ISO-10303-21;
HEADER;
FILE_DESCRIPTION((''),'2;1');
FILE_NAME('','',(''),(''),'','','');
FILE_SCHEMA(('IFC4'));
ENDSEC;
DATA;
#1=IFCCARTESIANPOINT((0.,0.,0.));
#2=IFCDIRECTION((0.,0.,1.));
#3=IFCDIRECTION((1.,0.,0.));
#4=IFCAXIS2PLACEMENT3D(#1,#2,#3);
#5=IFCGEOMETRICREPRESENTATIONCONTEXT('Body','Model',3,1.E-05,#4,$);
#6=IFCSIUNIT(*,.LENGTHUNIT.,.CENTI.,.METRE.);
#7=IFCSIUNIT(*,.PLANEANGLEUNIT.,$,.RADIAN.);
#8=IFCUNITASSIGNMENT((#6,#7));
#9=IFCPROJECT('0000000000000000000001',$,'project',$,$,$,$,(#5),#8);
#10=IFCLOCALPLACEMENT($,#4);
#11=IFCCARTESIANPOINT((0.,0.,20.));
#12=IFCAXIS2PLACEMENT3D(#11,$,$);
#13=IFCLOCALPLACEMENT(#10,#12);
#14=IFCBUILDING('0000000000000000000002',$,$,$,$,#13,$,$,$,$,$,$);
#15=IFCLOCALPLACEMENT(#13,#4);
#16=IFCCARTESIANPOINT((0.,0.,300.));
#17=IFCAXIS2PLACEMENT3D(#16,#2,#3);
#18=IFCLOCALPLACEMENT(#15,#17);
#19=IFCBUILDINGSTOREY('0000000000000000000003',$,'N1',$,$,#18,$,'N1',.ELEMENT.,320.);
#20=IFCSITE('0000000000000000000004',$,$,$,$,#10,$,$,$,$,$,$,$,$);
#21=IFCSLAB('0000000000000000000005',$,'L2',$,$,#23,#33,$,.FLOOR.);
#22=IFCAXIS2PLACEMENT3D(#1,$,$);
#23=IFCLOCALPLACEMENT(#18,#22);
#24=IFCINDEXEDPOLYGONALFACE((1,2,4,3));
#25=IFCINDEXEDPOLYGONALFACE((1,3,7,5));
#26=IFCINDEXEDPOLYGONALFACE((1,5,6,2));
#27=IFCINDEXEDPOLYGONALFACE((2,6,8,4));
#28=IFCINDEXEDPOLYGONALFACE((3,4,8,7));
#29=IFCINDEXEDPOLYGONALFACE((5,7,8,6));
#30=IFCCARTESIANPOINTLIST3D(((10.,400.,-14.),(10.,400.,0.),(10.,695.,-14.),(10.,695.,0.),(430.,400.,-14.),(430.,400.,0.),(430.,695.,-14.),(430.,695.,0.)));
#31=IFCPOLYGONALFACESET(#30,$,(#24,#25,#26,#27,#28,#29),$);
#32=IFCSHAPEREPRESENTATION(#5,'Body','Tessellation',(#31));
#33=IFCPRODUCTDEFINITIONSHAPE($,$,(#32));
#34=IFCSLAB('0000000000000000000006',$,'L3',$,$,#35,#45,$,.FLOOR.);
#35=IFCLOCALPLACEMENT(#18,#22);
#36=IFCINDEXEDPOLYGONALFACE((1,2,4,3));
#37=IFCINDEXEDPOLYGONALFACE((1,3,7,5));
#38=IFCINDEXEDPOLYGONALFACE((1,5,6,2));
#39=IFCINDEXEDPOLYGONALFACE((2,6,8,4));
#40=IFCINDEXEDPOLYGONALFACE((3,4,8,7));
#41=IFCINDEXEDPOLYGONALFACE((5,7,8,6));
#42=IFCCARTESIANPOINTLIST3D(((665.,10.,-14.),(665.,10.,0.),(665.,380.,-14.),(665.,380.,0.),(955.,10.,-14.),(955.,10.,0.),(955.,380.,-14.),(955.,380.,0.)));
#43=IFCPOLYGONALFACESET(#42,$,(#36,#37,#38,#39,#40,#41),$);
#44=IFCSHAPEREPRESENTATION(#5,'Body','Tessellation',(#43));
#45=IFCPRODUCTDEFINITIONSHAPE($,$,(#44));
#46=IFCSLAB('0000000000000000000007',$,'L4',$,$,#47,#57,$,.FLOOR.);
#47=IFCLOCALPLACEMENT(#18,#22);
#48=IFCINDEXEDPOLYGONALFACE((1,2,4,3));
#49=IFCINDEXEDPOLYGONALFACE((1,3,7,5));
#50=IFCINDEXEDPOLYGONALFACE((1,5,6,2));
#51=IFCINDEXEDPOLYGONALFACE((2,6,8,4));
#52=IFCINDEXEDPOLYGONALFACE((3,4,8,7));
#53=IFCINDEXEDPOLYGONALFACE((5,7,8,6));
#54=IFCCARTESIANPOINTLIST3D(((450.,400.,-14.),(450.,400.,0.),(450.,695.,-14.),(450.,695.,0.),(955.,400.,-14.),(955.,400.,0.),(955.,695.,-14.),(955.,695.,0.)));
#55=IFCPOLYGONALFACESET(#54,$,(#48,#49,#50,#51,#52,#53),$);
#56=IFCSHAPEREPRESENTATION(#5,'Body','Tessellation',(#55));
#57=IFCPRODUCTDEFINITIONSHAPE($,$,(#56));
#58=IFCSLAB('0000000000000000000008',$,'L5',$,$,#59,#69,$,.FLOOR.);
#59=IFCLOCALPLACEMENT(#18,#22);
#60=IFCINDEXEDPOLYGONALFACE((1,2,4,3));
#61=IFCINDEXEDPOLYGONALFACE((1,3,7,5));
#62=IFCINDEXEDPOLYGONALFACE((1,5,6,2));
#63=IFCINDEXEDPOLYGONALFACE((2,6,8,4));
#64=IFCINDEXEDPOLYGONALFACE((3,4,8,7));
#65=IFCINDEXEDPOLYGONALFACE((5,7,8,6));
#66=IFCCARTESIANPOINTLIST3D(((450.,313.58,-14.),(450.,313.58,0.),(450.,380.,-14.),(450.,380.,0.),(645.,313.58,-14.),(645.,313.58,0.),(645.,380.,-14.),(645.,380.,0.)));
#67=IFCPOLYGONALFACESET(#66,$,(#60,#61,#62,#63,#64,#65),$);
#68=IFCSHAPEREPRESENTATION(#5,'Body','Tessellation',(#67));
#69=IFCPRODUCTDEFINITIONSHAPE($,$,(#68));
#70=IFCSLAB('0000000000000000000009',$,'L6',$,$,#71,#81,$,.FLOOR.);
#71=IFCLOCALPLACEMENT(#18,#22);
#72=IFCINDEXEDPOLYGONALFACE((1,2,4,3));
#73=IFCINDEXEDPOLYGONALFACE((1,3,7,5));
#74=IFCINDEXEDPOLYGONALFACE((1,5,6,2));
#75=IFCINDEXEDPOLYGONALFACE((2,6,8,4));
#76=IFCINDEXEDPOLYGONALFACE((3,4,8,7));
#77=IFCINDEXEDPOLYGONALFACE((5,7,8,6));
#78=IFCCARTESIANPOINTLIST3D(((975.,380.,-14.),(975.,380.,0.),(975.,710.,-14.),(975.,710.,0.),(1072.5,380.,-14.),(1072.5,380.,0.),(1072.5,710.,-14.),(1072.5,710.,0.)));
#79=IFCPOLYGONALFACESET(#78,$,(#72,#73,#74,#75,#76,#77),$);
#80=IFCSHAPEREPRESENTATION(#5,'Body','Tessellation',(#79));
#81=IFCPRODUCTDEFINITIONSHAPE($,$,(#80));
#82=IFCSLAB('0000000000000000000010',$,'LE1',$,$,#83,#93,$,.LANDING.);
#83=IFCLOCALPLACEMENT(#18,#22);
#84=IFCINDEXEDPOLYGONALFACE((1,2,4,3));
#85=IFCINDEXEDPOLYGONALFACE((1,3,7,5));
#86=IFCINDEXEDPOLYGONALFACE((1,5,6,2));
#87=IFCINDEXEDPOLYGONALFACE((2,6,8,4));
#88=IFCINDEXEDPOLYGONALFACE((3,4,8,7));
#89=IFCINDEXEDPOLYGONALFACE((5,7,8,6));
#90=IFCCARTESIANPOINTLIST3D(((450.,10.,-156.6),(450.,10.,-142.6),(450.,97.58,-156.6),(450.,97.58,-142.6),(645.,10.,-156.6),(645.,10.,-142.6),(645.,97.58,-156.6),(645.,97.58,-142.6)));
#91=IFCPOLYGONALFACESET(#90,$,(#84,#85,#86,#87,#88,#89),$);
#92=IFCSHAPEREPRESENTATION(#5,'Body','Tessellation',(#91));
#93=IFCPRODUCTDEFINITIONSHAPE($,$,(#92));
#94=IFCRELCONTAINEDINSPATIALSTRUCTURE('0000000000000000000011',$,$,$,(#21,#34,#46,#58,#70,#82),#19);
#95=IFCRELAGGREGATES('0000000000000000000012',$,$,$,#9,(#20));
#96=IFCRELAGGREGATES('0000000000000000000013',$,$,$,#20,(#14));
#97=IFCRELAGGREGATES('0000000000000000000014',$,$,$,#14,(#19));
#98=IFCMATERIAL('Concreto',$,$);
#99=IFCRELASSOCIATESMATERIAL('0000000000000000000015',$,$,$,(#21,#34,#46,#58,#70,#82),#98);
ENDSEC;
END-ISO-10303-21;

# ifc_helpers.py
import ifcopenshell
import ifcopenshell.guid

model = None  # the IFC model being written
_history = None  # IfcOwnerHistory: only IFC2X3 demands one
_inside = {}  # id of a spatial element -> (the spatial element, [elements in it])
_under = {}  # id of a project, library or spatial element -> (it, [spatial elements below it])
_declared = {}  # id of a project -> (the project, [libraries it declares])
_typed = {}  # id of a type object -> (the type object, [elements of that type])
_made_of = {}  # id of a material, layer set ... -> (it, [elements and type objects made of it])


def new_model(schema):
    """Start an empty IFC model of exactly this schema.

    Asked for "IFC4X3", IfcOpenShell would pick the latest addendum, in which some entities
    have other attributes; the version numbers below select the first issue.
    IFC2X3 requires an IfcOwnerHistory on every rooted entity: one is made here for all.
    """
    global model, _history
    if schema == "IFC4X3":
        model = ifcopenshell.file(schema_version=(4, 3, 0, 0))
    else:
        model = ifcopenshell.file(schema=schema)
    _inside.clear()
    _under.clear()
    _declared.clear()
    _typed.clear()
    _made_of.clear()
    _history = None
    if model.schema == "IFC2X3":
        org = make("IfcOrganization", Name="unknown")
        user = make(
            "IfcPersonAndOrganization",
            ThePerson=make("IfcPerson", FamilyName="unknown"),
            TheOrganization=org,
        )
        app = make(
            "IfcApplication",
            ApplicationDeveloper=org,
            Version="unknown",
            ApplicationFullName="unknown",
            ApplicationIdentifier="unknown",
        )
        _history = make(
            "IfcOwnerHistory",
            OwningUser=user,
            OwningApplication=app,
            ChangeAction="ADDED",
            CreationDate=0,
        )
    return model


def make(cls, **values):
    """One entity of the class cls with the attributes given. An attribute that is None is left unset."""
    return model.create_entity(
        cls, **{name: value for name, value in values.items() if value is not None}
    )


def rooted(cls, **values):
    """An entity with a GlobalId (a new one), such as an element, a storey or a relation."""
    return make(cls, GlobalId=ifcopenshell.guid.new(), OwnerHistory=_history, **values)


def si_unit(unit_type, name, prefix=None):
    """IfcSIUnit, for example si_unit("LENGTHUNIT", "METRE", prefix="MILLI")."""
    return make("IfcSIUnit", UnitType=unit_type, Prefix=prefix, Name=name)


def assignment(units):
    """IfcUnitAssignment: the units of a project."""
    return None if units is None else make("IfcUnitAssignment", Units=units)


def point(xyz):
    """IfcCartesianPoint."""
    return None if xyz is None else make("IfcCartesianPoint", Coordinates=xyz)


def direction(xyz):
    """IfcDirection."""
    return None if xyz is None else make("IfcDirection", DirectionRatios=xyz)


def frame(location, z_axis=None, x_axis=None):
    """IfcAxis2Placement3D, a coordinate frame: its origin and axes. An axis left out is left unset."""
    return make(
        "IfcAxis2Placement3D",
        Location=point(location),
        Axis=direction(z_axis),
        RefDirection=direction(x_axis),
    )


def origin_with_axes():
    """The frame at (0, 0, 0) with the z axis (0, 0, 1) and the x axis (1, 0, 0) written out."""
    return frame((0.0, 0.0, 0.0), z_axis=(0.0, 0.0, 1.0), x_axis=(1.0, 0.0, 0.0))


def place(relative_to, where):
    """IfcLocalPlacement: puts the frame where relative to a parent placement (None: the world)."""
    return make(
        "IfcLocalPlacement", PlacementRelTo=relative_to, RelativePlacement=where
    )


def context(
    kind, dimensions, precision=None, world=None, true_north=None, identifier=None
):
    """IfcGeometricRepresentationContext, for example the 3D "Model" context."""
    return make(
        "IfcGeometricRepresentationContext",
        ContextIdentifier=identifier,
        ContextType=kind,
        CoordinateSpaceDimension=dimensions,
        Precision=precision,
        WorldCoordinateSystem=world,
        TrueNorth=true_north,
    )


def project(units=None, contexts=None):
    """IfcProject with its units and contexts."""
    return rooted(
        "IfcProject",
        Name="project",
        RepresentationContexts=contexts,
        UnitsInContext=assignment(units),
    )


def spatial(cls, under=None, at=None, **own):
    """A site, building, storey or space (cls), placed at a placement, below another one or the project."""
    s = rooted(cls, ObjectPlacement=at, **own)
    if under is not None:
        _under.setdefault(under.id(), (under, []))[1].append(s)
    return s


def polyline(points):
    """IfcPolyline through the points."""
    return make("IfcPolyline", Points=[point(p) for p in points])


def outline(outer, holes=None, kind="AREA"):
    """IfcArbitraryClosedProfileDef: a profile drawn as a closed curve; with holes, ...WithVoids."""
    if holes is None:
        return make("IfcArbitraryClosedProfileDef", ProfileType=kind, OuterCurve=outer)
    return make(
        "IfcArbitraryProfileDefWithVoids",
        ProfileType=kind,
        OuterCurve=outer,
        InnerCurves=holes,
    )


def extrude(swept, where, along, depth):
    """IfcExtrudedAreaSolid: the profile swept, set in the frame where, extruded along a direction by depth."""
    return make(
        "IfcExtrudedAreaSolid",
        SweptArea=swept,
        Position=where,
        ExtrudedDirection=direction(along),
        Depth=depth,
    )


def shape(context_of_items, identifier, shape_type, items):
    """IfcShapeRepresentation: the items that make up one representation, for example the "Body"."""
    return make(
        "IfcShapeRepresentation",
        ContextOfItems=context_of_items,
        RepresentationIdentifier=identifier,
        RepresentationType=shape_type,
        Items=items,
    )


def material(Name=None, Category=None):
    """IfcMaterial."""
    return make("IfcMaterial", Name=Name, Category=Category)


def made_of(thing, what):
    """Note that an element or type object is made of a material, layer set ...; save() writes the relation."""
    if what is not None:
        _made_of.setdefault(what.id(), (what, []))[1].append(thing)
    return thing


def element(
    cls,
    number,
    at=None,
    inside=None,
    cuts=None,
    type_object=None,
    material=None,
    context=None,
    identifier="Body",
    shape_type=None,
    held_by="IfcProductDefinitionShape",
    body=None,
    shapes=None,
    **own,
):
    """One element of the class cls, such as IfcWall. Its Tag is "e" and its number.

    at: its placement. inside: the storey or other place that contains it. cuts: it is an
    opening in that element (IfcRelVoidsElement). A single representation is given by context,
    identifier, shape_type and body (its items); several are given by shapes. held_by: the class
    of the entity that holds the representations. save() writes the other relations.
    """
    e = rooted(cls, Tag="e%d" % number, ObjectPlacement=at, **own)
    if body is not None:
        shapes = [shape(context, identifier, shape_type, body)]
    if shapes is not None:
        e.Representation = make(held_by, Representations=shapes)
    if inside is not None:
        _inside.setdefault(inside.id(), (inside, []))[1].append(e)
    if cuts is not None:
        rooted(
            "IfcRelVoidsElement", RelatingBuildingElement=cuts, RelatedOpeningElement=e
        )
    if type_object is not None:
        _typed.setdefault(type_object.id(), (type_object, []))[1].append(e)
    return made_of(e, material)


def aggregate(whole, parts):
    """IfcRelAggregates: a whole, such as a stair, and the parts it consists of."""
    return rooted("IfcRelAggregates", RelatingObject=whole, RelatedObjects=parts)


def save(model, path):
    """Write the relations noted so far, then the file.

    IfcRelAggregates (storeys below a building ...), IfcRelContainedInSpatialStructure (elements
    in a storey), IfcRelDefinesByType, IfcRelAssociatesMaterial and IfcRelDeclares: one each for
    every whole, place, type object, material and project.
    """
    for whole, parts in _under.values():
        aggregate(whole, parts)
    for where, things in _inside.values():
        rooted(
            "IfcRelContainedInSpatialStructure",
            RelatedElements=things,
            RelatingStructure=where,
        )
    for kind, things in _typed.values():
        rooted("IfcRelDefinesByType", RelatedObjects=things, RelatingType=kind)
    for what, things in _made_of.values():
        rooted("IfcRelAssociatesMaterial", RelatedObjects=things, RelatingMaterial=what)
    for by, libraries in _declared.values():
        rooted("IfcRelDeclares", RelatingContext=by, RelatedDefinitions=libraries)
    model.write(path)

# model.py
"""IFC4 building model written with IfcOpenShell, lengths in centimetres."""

from ifc_helpers import new_model, si_unit, frame, origin_with_axes, place, context, project, spatial, polyline, outline, extrude, material, element, save


model = new_model("IFC4")

# Units and contexts
model_context = context("Model", 3, precision=1e-05, world=origin_with_axes(), identifier="Body")
ifc_project = project(units=[si_unit("LENGTHUNIT", "METRE", prefix="CENTI"), si_unit("PLANEANGLEUNIT", "RADIAN")], contexts=[model_context])

# Site, building, storey
site_placement = place(None, origin_with_axes())
site = spatial("IfcSite", under=ifc_project, at=site_placement)
building_placement = place(site_placement, frame((0.0, 0.0, 20.0)))
building = spatial("IfcBuilding", under=site, at=building_placement)
placement = place(building_placement, origin_with_axes())
storey_placement = place(placement, frame((0.0, 0.0, 300.0), z_axis=(0.0, 0.0, 1.0), x_axis=(1.0, 0.0, 0.0)))
storey = spatial("IfcBuildingStorey", under=building, at=storey_placement, Name="N1", LongName="N1", CompositionType="ELEMENT", Elevation=320.0)

# Shared definitions
ifc_material = material(Name="Concreto")

# Slabs
slab_1_placement = place(storey_placement, frame((220.0, 547.5, 0.0), z_axis=(0.0, 0.0, 1.0), x_axis=(1.0, 0.0, 0.0)))
element("IfcSlab", 1, at=slab_1_placement, inside=storey, material=ifc_material, Name="L2", PredefinedType="FLOOR", context=model_context, shape_type="SolidModel", body=[
    extrude(outline(polyline([(210.0, 147.5), (-210.0, 147.5), (-210.0, -147.5), (210.0, -147.5), (210.0, 147.5), (210.0, 147.5)])), frame((0.0, 0.0, -14.0), z_axis=(0.0, 0.0, 1.0), x_axis=(1.0, 0.0, 0.0)), (0.0, 0.0, 1.0), 14.0),
])
slab_2_placement = place(storey_placement, frame((810.0, 195.0, 0.0), z_axis=(0.0, 0.0, 1.0), x_axis=(1.0, 0.0, 0.0)))
element("IfcSlab", 2, at=slab_2_placement, inside=storey, material=ifc_material, Name="L3", PredefinedType="FLOOR", context=model_context, shape_type="SolidModel", body=[
    extrude(outline(polyline([(145.0, 185.0), (-145.0, 185.0), (-145.0, -185.0), (145.0, -185.0), (145.0, 185.0), (145.0, 185.0)])), frame((0.0, 0.0, -14.0), z_axis=(0.0, 0.0, 1.0), x_axis=(1.0, 0.0, 0.0)), (0.0, 0.0, 1.0), 14.0),
])
slab_3_placement = place(storey_placement, frame((702.5, 547.5, 0.0), z_axis=(0.0, 0.0, 1.0), x_axis=(1.0, 0.0, 0.0)))
element("IfcSlab", 3, at=slab_3_placement, inside=storey, material=ifc_material, Name="L4", PredefinedType="FLOOR", context=model_context, shape_type="SolidModel", body=[
    extrude(outline(polyline([(252.5, 147.5), (-252.5, 147.5), (-252.5, -147.5), (252.5, -147.5), (252.5, 147.5), (252.5, 147.5)])), frame((0.0, 0.0, -14.0), z_axis=(0.0, 0.0, 1.0), x_axis=(1.0, 0.0, 0.0)), (0.0, 0.0, 1.0), 14.0),
])
slab_4_placement = place(storey_placement, frame((547.5, 346.79, 0.0), z_axis=(0.0, 0.0, 1.0), x_axis=(1.0, 0.0, 0.0)))
element("IfcSlab", 4, at=slab_4_placement, inside=storey, material=ifc_material, Name="L5", PredefinedType="FLOOR", context=model_context, shape_type="SolidModel", body=[
    extrude(outline(polyline([(97.5, 33.21), (-97.5, 33.21), (-97.5, -33.21), (97.5, -33.21), (97.5, 33.21), (97.5, 33.21)])), frame((0.0, 0.0, -14.0), z_axis=(0.0, 0.0, 1.0), x_axis=(1.0, 0.0, 0.0)), (0.0, 0.0, 1.0), 14.0),
])
slab_5_placement = place(storey_placement, frame((1023.75, 545.0, 0.0), z_axis=(0.0, 0.0, 1.0), x_axis=(1.0, 0.0, 0.0)))
element("IfcSlab", 5, at=slab_5_placement, inside=storey, material=ifc_material, Name="L6", PredefinedType="FLOOR", context=model_context, shape_type="SolidModel", body=[
    extrude(outline(polyline([(48.75, 165.0), (-48.75, 165.0), (-48.75, -165.0), (48.75, -165.0), (48.75, 165.0), (48.75, 165.0)])), frame((0.0, 0.0, -14.0), z_axis=(0.0, 0.0, 1.0), x_axis=(1.0, 0.0, 0.0)), (0.0, 0.0, 1.0), 14.0),
])
slab_6_placement = place(storey_placement, frame((547.5, 53.79, -142.6), z_axis=(0.0, 0.0, 1.0), x_axis=(1.0, 0.0, 0.0)))
element("IfcSlab", 6, at=slab_6_placement, inside=storey, material=ifc_material, Name="LE1", PredefinedType="LANDING", context=model_context, shape_type="SolidModel", body=[
    extrude(outline(polyline([(97.5, 43.79), (-97.5, 43.79), (-97.5, -43.79), (97.5, -43.79), (97.5, 43.79), (97.5, 43.79)])), frame((0.0, 0.0, -14.0), z_axis=(0.0, 0.0, 1.0), x_axis=(1.0, 0.0, 0.0)), (0.0, 0.0, 1.0), 14.0),
])

save(model, "model.ifc")
